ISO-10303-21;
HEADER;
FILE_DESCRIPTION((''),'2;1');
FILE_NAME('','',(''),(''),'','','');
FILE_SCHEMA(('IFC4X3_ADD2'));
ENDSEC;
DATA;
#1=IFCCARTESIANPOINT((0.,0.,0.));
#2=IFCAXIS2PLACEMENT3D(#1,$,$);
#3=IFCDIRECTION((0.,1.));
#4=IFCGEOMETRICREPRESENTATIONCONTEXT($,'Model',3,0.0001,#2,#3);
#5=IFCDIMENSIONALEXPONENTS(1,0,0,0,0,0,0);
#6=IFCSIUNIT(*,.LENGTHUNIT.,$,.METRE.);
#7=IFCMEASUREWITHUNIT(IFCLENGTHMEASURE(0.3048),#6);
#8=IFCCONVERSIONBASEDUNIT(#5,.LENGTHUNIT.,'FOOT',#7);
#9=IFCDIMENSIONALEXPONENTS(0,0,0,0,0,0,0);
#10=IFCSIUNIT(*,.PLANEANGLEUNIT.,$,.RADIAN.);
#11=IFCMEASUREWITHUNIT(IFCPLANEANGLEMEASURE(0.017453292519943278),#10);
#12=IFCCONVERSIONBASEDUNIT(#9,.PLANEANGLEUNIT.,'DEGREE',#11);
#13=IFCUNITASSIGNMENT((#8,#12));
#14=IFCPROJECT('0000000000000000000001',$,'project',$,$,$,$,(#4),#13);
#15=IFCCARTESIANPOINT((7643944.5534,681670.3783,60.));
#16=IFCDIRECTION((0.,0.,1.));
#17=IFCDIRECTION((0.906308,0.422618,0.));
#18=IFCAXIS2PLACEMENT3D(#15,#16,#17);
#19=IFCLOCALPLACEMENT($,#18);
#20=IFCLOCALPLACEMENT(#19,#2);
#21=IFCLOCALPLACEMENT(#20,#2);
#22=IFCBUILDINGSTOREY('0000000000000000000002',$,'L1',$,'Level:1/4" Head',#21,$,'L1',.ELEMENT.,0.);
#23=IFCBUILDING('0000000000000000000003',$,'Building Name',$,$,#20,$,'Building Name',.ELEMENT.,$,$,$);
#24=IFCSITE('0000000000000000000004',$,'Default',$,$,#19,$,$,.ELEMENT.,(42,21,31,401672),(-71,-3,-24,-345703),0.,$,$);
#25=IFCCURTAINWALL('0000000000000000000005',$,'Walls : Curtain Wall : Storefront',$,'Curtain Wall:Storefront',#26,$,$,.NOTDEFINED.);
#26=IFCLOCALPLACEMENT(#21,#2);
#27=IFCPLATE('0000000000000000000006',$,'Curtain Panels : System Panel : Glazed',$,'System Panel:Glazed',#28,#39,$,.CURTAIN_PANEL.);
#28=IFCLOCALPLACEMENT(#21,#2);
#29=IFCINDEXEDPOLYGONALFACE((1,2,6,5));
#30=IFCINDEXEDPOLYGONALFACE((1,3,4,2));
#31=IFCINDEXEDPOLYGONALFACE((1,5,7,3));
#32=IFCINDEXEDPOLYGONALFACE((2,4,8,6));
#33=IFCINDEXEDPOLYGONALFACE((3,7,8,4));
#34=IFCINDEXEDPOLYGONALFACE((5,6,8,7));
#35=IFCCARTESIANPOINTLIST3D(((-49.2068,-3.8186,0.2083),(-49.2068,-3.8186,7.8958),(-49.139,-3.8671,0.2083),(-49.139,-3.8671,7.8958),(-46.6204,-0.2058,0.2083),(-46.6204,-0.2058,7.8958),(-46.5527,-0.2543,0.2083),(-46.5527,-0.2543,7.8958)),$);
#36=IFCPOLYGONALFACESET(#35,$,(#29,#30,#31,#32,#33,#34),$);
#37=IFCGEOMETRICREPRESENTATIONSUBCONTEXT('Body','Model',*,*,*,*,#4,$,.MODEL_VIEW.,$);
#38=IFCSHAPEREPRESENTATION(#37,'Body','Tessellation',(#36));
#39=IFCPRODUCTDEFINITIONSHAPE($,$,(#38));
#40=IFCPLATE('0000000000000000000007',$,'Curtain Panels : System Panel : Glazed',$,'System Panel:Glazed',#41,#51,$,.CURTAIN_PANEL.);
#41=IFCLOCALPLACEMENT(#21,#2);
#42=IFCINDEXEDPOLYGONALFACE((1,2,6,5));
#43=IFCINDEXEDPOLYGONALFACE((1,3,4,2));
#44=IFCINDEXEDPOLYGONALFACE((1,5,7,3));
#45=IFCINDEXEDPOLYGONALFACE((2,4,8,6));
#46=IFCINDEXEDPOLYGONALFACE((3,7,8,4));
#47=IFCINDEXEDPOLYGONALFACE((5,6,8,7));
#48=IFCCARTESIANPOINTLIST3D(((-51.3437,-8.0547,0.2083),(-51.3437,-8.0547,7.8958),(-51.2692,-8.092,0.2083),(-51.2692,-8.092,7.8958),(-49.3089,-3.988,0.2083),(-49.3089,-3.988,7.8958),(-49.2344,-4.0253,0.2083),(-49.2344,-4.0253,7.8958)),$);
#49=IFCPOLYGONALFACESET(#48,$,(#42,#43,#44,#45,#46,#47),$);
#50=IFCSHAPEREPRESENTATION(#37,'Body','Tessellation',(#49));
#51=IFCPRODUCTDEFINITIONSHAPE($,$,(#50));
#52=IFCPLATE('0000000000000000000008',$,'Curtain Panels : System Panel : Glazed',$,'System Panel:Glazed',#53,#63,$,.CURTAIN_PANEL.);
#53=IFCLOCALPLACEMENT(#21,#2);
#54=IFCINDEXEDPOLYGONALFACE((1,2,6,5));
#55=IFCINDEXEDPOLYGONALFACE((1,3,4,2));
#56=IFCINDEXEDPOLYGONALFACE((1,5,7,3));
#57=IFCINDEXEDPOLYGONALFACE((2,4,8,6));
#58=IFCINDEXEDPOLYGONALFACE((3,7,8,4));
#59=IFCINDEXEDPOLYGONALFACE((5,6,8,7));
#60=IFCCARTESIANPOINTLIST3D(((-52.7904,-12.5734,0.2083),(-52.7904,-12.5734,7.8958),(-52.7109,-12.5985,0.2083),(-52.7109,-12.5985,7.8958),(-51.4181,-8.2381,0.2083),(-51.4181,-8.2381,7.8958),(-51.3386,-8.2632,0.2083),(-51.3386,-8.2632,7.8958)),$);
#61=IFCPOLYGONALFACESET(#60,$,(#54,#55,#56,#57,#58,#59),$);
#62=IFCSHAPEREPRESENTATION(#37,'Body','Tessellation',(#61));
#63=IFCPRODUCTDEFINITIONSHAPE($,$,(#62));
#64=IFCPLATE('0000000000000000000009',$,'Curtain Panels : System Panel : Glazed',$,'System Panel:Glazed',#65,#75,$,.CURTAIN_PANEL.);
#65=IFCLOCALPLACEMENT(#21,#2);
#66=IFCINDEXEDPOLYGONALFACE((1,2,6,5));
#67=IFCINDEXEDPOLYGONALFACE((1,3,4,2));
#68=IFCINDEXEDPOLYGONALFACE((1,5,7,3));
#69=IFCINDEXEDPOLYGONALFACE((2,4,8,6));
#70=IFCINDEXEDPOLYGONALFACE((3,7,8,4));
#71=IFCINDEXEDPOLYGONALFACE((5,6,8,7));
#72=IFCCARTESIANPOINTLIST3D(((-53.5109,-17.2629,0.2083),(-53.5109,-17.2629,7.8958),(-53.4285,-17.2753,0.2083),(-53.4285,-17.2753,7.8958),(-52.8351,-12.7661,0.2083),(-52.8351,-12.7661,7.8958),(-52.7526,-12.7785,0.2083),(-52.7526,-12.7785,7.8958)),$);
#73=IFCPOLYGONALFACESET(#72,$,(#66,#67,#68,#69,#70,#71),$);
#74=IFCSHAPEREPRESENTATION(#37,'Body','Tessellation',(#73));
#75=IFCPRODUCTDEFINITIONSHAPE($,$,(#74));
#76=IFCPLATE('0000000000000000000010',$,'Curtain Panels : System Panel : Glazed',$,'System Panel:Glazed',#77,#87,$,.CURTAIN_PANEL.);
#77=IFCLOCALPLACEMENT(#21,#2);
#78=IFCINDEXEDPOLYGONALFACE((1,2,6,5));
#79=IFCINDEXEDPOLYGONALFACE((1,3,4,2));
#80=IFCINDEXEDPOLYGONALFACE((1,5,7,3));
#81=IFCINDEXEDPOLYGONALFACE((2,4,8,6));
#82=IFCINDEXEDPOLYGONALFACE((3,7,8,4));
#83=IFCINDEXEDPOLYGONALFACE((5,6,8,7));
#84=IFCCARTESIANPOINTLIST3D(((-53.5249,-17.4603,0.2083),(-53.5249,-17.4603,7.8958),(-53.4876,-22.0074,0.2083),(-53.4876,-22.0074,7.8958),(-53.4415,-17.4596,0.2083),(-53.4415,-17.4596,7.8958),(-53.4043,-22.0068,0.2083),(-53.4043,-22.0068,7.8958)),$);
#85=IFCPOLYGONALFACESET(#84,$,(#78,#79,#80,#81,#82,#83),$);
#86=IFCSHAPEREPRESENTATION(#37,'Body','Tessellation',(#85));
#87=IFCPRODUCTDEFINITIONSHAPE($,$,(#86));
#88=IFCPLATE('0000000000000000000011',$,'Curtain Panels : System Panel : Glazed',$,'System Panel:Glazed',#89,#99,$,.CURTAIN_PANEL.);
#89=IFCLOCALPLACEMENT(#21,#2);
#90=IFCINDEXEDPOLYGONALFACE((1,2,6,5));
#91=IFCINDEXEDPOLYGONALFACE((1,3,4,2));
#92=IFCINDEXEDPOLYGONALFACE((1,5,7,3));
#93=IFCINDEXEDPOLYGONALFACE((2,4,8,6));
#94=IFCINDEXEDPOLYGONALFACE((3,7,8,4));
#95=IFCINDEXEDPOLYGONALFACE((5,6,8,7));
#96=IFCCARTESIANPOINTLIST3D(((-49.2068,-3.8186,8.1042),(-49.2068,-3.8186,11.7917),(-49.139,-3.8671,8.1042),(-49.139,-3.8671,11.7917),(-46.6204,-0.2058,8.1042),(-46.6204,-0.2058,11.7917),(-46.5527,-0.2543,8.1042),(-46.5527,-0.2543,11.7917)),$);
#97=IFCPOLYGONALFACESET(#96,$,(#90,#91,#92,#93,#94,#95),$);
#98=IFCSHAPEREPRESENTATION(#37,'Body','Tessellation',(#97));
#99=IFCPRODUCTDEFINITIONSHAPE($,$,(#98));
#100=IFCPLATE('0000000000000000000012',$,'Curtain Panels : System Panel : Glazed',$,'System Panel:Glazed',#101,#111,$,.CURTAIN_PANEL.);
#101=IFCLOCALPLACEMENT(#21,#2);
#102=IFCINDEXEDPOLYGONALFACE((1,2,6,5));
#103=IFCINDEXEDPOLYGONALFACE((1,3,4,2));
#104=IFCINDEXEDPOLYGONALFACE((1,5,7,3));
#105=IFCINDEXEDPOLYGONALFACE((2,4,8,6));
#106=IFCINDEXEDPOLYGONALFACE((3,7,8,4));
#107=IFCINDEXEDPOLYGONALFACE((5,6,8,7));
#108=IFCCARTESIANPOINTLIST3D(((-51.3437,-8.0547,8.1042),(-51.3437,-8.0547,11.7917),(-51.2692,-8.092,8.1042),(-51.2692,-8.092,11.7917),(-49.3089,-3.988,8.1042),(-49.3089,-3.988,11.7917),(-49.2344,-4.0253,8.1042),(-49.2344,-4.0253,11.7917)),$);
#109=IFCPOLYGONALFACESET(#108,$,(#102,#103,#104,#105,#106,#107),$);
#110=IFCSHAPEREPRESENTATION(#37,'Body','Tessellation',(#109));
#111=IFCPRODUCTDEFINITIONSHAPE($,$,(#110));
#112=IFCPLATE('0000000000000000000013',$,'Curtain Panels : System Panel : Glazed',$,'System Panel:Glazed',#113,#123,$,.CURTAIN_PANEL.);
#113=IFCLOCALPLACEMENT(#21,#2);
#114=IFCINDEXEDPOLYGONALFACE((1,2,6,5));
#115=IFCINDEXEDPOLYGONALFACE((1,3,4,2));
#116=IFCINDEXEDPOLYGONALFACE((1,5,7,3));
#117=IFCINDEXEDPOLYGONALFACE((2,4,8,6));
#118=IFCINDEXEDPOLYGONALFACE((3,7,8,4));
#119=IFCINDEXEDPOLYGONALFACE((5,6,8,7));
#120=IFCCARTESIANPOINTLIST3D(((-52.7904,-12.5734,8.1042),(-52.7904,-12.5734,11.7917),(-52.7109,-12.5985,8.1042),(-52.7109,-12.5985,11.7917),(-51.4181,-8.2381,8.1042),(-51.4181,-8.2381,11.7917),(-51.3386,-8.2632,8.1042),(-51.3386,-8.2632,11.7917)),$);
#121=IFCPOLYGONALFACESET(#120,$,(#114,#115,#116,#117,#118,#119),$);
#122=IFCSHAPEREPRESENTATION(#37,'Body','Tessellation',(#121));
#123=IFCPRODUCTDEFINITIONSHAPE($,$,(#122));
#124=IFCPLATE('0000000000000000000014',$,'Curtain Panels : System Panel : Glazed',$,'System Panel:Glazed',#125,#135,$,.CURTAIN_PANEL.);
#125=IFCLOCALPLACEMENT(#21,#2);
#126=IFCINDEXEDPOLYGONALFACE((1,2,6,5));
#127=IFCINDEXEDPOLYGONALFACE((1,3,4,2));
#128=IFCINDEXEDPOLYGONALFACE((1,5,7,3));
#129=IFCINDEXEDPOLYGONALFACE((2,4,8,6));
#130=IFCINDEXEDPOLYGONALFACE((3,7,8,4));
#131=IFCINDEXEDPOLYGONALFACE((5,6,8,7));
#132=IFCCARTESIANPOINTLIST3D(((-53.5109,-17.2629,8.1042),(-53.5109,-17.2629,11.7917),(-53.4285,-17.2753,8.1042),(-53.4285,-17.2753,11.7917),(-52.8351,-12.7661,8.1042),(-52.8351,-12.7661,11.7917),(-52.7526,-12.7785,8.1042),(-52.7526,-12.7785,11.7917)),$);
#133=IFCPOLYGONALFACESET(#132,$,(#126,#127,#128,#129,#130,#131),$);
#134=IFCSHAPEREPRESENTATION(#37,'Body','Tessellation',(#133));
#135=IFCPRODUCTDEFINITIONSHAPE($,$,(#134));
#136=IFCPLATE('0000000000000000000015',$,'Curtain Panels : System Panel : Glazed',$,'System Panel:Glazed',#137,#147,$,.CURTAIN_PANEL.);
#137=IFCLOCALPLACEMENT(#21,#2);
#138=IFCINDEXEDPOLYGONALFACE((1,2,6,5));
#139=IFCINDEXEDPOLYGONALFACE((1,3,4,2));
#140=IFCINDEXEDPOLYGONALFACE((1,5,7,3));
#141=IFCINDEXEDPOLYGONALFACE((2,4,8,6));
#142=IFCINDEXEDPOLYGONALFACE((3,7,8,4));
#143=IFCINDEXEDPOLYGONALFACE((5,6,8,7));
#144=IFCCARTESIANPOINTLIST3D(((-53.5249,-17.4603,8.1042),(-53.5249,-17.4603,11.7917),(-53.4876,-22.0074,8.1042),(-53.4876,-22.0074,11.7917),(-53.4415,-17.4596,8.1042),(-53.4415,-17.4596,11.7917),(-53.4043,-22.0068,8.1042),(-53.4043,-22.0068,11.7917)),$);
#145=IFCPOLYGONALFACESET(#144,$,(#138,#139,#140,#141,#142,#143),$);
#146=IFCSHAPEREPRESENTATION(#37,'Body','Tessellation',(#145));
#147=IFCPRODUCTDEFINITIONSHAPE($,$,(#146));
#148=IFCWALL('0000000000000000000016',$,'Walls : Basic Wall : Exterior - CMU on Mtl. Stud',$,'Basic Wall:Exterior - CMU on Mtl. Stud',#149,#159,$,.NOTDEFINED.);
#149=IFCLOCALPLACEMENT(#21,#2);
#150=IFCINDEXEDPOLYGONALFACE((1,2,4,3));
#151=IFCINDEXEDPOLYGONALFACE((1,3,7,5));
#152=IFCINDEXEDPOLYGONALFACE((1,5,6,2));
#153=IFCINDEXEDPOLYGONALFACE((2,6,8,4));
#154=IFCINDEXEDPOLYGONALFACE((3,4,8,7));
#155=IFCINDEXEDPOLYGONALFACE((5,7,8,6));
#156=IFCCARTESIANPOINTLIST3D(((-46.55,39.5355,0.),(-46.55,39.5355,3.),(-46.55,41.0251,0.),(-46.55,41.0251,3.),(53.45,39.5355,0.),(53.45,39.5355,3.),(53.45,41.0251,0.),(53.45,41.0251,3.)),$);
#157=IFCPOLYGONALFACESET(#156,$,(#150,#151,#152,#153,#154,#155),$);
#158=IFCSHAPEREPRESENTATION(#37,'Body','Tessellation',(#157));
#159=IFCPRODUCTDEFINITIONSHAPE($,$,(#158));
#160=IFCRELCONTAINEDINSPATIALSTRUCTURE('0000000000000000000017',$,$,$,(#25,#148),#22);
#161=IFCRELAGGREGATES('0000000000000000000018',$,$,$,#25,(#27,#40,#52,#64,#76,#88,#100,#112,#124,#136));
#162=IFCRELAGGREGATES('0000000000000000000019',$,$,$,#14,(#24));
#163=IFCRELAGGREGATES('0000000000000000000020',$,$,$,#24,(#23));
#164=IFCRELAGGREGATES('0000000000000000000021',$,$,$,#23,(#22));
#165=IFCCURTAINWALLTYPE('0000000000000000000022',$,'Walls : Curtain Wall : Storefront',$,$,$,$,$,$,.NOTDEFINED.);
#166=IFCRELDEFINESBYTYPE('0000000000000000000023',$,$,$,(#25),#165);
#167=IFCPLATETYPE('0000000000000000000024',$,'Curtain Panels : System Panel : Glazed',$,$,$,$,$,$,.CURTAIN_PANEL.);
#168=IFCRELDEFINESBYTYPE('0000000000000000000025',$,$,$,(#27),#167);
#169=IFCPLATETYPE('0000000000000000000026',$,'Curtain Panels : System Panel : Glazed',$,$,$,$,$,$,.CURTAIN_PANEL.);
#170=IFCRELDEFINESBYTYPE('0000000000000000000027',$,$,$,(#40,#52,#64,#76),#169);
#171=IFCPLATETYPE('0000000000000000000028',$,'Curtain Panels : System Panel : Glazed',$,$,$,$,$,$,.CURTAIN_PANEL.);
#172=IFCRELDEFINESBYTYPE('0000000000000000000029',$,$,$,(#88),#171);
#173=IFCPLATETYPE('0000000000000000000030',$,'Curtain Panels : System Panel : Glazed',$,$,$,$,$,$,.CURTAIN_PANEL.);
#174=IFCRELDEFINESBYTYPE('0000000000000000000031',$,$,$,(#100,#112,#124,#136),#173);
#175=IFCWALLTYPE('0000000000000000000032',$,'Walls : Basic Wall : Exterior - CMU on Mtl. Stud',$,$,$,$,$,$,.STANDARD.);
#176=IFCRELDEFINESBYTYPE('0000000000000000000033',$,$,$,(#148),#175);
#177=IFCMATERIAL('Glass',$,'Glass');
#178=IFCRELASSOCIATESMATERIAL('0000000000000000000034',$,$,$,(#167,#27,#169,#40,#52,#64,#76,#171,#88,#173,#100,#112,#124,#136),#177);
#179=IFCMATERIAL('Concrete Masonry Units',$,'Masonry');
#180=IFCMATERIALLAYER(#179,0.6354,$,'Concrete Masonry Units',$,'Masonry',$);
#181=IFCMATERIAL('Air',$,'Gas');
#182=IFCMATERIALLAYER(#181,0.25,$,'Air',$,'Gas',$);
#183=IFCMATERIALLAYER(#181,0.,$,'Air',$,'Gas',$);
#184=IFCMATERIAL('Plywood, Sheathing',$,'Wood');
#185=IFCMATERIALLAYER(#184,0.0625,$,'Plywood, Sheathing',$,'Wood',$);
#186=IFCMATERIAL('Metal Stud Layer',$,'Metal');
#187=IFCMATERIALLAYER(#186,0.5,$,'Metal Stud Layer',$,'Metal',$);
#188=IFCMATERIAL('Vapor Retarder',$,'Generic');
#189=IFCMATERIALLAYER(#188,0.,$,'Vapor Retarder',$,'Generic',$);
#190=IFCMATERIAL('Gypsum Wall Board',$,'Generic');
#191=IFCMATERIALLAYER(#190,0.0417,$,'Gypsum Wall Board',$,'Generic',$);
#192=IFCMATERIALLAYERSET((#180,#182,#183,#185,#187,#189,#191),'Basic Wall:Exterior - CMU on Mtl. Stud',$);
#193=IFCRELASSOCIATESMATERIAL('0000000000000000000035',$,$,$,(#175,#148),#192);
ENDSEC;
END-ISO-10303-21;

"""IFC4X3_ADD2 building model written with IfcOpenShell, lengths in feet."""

from ifc_helpers import new_model, entity, si_unit, converted_unit, direction, frame, frame_2d, origin, place, context, subcontext, project, spatial, rectangle, extrude, source, transform, mapped, material, layer, layer_set, type_object, type_shapes, element, aggregate, save


model = new_model("IFC4X3_ADD2")

# Units and contexts
model_context = context("Model", 3, precision=0.0001, world=origin(), true_north=direction((0.0, 1.0)))
body_context = subcontext(model_context, "Body", "Model", "MODEL_VIEW")
ifc_project = project(units=[converted_unit("LENGTHUNIT", "FOOT", entity("IfcLengthMeasure", 0.3048), si_unit("LENGTHUNIT", "METRE"), dimensions=[1, 0, 0, 0, 0, 0, 0]), converted_unit("PLANEANGLEUNIT", "DEGREE", entity("IfcPlaneAngleMeasure", 0.017453292519943278), si_unit("PLANEANGLEUNIT", "RADIAN"), dimensions=[0, 0, 0, 0, 0, 0, 0])], contexts=[model_context])

# Site, building, storey
site_placement = place(None, frame((7643944.5534, 681670.3783, 60.0), z_axis=(0.0, 0.0, 1.0), x_axis=(0.906308, 0.422618, 0.0)))
site = spatial("IfcSite", under=ifc_project, at=site_placement, Name="Default", CompositionType="ELEMENT", RefLatitude=(42, 21, 31, 401672), RefLongitude=(-71, -3, -24, -345703), RefElevation=0.0)
building_placement = place(site_placement, origin())
building = spatial("IfcBuilding", under=site, at=building_placement, Name="Building Name", LongName="Building Name", CompositionType="ELEMENT")
storey_placement = place(building_placement, origin())
storey = spatial("IfcBuildingStorey", under=building, at=storey_placement, Name="L1", ObjectType="Level:1/4\" Head", LongName="L1", CompositionType="ELEMENT", Elevation=0.0)

# Curtain wall, plates
curtain_wall_type = type_object("IfcCurtainWallType", Name="Walls : Curtain Wall : Storefront", PredefinedType="NOTDEFINED")
curtain_wall_placement = place(storey_placement, origin())
curtain_wall = element("IfcCurtainWall", 1, at=curtain_wall_placement, inside=storey, type_object=curtain_wall_type, Name="Walls : Curtain Wall : Storefront", ObjectType="Curtain Wall:Storefront", PredefinedType="NOTDEFINED")
ifc_material_1 = material(Name="Glass", Category="Glass")
plate_type_1 = type_object("IfcPlateType", Name="Curtain Panels : System Panel : Glazed", PredefinedType="CURTAIN_PANEL", material=ifc_material_1)
shared_shape_1 = source(origin(), body_context, "Body", "SweptSolid", [
    extrude(rectangle(XDim=0.0833, YDim=4.4431, at=frame_2d((0.0, 0.0), x_axis=(1.0, 0.0))), frame((2.2216, 0.0417, 0.0), z_axis=(0.0, 0.0, 1.0), x_axis=(0.0, 1.0, 0.0)), (0.0, 0.0, 1.0), 7.6875),
])
type_shapes(plate_type_1, [shared_shape_1])
plate_1_placement = place(curtain_wall_placement, frame((-46.6204, -0.2058, 0.2083), z_axis=(0.0, 0.0, 1.0), x_axis=(-0.582096, -0.81312, 0.0)))
plate_1 = element("IfcPlate", 2, at=plate_1_placement, type_object=plate_type_1, material=ifc_material_1, Name="Curtain Panels : System Panel : Glazed", ObjectType="System Panel:Glazed", PredefinedType="CURTAIN_PANEL", context=body_context, shape_type="MappedRepresentation", body=[
    mapped(shared_shape_1, transform((0.0, 0.0, 0.0), scale=1.0)),
])
plate_type_2 = type_object("IfcPlateType", Name="Curtain Panels : System Panel : Glazed", PredefinedType="CURTAIN_PANEL", material=ifc_material_1)
shared_shape_2 = source(origin(), body_context, "Body", "SweptSolid", [
    extrude(rectangle(XDim=0.0833, YDim=4.5473, at=frame_2d((0.0, 0.0), x_axis=(1.0, 0.0))), frame((2.2737, 0.0417, 0.0), z_axis=(0.0, 0.0, 1.0), x_axis=(0.0, 1.0, 0.0)), (0.0, 0.0, 1.0), 7.6875),
])
type_shapes(plate_type_2, [shared_shape_2])
plate_2_placement = place(curtain_wall_placement, frame((-49.3089, -3.988, 0.2083), z_axis=(0.0, 0.0, 1.0), x_axis=(-0.447467, -0.8943, 0.0)))
plate_2 = element("IfcPlate", 3, at=plate_2_placement, type_object=plate_type_2, material=ifc_material_1, Name="Curtain Panels : System Panel : Glazed", ObjectType="System Panel:Glazed", PredefinedType="CURTAIN_PANEL", context=body_context, shape_type="MappedRepresentation", body=[
    mapped(shared_shape_2, transform((0.0, 0.0, 0.0), scale=1.0)),
])
plate_3_placement = place(curtain_wall_placement, frame((-51.4181, -8.2381, 0.2083), z_axis=(0.0, 0.0, 1.0), x_axis=(-0.301779, -0.953378, 0.0)))
plate_3 = element("IfcPlate", 4, at=plate_3_placement, type_object=plate_type_2, material=ifc_material_1, Name="Curtain Panels : System Panel : Glazed", ObjectType="System Panel:Glazed", PredefinedType="CURTAIN_PANEL", context=body_context, shape_type="MappedRepresentation", body=[
    mapped(shared_shape_2, transform((0.0, 0.0, 0.0), scale=1.0)),
])
plate_4_placement = place(curtain_wall_placement, frame((-52.8351, -12.7661, 0.2083), z_axis=(0.0, 0.0, 1.0), x_axis=(-0.148632, -0.988893, 0.0)))
plate_4 = element("IfcPlate", 5, at=plate_4_placement, type_object=plate_type_2, material=ifc_material_1, Name="Curtain Panels : System Panel : Glazed", ObjectType="System Panel:Glazed", PredefinedType="CURTAIN_PANEL", context=body_context, shape_type="MappedRepresentation", body=[
    mapped(shared_shape_2, transform((0.0, 0.0, 0.0), scale=1.0)),
])
plate_5_placement = place(curtain_wall_placement, frame((-53.5249, -17.4603, 0.2083), z_axis=(0.0, 0.0, 1.0), x_axis=(0.008188, -0.999966, 0.0)))
plate_5 = element("IfcPlate", 6, at=plate_5_placement, type_object=plate_type_2, material=ifc_material_1, Name="Curtain Panels : System Panel : Glazed", ObjectType="System Panel:Glazed", PredefinedType="CURTAIN_PANEL", context=body_context, shape_type="MappedRepresentation", body=[
    mapped(shared_shape_2, transform((0.0, 0.0, 0.0), scale=1.0)),
])
plate_type_3 = type_object("IfcPlateType", Name="Curtain Panels : System Panel : Glazed", PredefinedType="CURTAIN_PANEL", material=ifc_material_1)
shared_shape_3 = source(origin(), body_context, "Body", "SweptSolid", [
    extrude(rectangle(XDim=0.0833, YDim=4.4431, at=frame_2d((0.0, 0.0), x_axis=(1.0, 0.0))), frame((2.2216, 0.0417, 0.0), z_axis=(0.0, 0.0, 1.0), x_axis=(0.0, 1.0, 0.0)), (0.0, 0.0, 1.0), 3.6875),
])
type_shapes(plate_type_3, [shared_shape_3])
plate_6_placement = place(curtain_wall_placement, frame((-46.6204, -0.2058, 8.1042), z_axis=(0.0, 0.0, 1.0), x_axis=(-0.582096, -0.81312, 0.0)))
plate_6 = element("IfcPlate", 7, at=plate_6_placement, type_object=plate_type_3, material=ifc_material_1, Name="Curtain Panels : System Panel : Glazed", ObjectType="System Panel:Glazed", PredefinedType="CURTAIN_PANEL", context=body_context, shape_type="MappedRepresentation", body=[
    mapped(shared_shape_3, transform((0.0, 0.0, 0.0), scale=1.0)),
])
plate_type_4 = type_object("IfcPlateType", Name="Curtain Panels : System Panel : Glazed", PredefinedType="CURTAIN_PANEL", material=ifc_material_1)
shared_shape_4 = source(origin(), body_context, "Body", "SweptSolid", [
    extrude(rectangle(XDim=0.0833, YDim=4.5473, at=frame_2d((0.0, 0.0), x_axis=(1.0, 0.0))), frame((2.2737, 0.0417, 0.0), z_axis=(0.0, 0.0, 1.0), x_axis=(0.0, 1.0, 0.0)), (0.0, 0.0, 1.0), 3.6875),
])
type_shapes(plate_type_4, [shared_shape_4])
plate_7_placement = place(curtain_wall_placement, frame((-49.3089, -3.988, 8.1042), z_axis=(0.0, 0.0, 1.0), x_axis=(-0.447467, -0.8943, 0.0)))
plate_7 = element("IfcPlate", 8, at=plate_7_placement, type_object=plate_type_4, material=ifc_material_1, Name="Curtain Panels : System Panel : Glazed", ObjectType="System Panel:Glazed", PredefinedType="CURTAIN_PANEL", context=body_context, shape_type="MappedRepresentation", body=[
    mapped(shared_shape_4, transform((0.0, 0.0, 0.0), scale=1.0)),
])
plate_8_placement = place(curtain_wall_placement, frame((-51.4181, -8.2381, 8.1042), z_axis=(0.0, 0.0, 1.0), x_axis=(-0.301779, -0.953378, 0.0)))
plate_8 = element("IfcPlate", 9, at=plate_8_placement, type_object=plate_type_4, material=ifc_material_1, Name="Curtain Panels : System Panel : Glazed", ObjectType="System Panel:Glazed", PredefinedType="CURTAIN_PANEL", context=body_context, shape_type="MappedRepresentation", body=[
    mapped(shared_shape_4, transform((0.0, 0.0, 0.0), scale=1.0)),
])
plate_9_placement = place(curtain_wall_placement, frame((-52.8351, -12.7661, 8.1042), z_axis=(0.0, 0.0, 1.0), x_axis=(-0.148632, -0.988893, 0.0)))
plate_9 = element("IfcPlate", 10, at=plate_9_placement, type_object=plate_type_4, material=ifc_material_1, Name="Curtain Panels : System Panel : Glazed", ObjectType="System Panel:Glazed", PredefinedType="CURTAIN_PANEL", context=body_context, shape_type="MappedRepresentation", body=[
    mapped(shared_shape_4, transform((0.0, 0.0, 0.0), scale=1.0)),
])
plate_10_placement = place(curtain_wall_placement, frame((-53.5249, -17.4603, 8.1042), z_axis=(0.0, 0.0, 1.0), x_axis=(0.008188, -0.999966, 0.0)))
plate_10 = element("IfcPlate", 11, at=plate_10_placement, type_object=plate_type_4, material=ifc_material_1, Name="Curtain Panels : System Panel : Glazed", ObjectType="System Panel:Glazed", PredefinedType="CURTAIN_PANEL", context=body_context, shape_type="MappedRepresentation", body=[
    mapped(shared_shape_4, transform((0.0, 0.0, 0.0), scale=1.0)),
])
aggregate(curtain_wall, [plate_1, plate_2, plate_3, plate_4, plate_5, plate_6, plate_7, plate_8, plate_9, plate_10])

# Wall
ifc_material_2 = material(Name="Concrete Masonry Units", Category="Masonry")
ifc_layer_1 = layer(ifc_material_2, 0.6354, Name="Concrete Masonry Units", Category="Masonry")
ifc_material_3 = material(Name="Air", Category="Gas")
ifc_layer_2 = layer(ifc_material_3, 0.25, Name="Air", Category="Gas")
ifc_layer_3 = layer(ifc_material_3, 0.0, Name="Air", Category="Gas")
ifc_material_4 = material(Name="Plywood, Sheathing", Category="Wood")
ifc_layer_4 = layer(ifc_material_4, 0.0625, Name="Plywood, Sheathing", Category="Wood")
ifc_material_5 = material(Name="Metal Stud Layer", Category="Metal")
ifc_layer_5 = layer(ifc_material_5, 0.5, Name="Metal Stud Layer", Category="Metal")
ifc_material_6 = material(Name="Vapor Retarder", Category="Generic")
ifc_layer_6 = layer(ifc_material_6, 0.0, Name="Vapor Retarder", Category="Generic")
ifc_material_7 = material(Name="Gypsum Wall Board", Category="Generic")
ifc_layer_7 = layer(ifc_material_7, 0.0417, Name="Gypsum Wall Board", Category="Generic")
ifc_layer_set_1 = layer_set([ifc_layer_1, ifc_layer_2, ifc_layer_3, ifc_layer_4, ifc_layer_5, ifc_layer_6, ifc_layer_7], Name="Basic Wall:Exterior - CMU on Mtl. Stud")
wall_type_1 = type_object("IfcWallType", Name="Walls : Basic Wall : Exterior - CMU on Mtl. Stud", PredefinedType="STANDARD", material=ifc_layer_set_1)
wall_1_placement = place(storey_placement, frame((-46.55, 40.2803, 0.0)))
element("IfcWall", 12, at=wall_1_placement, inside=storey, type_object=wall_type_1, material=ifc_layer_set_1, Name="Walls : Basic Wall : Exterior - CMU on Mtl. Stud", ObjectType="Basic Wall:Exterior - CMU on Mtl. Stud", PredefinedType="NOTDEFINED", context=body_context, shape_type="SweptSolid", body=[
    extrude(rectangle(XDim=100.0, YDim=1.4896, at=frame_2d((50.0, 0.0), x_axis=(-1.0, 0.0))), origin(), (0.0, 0.0, 1.0), 3.0),
])

save(model, "model.ifc")
